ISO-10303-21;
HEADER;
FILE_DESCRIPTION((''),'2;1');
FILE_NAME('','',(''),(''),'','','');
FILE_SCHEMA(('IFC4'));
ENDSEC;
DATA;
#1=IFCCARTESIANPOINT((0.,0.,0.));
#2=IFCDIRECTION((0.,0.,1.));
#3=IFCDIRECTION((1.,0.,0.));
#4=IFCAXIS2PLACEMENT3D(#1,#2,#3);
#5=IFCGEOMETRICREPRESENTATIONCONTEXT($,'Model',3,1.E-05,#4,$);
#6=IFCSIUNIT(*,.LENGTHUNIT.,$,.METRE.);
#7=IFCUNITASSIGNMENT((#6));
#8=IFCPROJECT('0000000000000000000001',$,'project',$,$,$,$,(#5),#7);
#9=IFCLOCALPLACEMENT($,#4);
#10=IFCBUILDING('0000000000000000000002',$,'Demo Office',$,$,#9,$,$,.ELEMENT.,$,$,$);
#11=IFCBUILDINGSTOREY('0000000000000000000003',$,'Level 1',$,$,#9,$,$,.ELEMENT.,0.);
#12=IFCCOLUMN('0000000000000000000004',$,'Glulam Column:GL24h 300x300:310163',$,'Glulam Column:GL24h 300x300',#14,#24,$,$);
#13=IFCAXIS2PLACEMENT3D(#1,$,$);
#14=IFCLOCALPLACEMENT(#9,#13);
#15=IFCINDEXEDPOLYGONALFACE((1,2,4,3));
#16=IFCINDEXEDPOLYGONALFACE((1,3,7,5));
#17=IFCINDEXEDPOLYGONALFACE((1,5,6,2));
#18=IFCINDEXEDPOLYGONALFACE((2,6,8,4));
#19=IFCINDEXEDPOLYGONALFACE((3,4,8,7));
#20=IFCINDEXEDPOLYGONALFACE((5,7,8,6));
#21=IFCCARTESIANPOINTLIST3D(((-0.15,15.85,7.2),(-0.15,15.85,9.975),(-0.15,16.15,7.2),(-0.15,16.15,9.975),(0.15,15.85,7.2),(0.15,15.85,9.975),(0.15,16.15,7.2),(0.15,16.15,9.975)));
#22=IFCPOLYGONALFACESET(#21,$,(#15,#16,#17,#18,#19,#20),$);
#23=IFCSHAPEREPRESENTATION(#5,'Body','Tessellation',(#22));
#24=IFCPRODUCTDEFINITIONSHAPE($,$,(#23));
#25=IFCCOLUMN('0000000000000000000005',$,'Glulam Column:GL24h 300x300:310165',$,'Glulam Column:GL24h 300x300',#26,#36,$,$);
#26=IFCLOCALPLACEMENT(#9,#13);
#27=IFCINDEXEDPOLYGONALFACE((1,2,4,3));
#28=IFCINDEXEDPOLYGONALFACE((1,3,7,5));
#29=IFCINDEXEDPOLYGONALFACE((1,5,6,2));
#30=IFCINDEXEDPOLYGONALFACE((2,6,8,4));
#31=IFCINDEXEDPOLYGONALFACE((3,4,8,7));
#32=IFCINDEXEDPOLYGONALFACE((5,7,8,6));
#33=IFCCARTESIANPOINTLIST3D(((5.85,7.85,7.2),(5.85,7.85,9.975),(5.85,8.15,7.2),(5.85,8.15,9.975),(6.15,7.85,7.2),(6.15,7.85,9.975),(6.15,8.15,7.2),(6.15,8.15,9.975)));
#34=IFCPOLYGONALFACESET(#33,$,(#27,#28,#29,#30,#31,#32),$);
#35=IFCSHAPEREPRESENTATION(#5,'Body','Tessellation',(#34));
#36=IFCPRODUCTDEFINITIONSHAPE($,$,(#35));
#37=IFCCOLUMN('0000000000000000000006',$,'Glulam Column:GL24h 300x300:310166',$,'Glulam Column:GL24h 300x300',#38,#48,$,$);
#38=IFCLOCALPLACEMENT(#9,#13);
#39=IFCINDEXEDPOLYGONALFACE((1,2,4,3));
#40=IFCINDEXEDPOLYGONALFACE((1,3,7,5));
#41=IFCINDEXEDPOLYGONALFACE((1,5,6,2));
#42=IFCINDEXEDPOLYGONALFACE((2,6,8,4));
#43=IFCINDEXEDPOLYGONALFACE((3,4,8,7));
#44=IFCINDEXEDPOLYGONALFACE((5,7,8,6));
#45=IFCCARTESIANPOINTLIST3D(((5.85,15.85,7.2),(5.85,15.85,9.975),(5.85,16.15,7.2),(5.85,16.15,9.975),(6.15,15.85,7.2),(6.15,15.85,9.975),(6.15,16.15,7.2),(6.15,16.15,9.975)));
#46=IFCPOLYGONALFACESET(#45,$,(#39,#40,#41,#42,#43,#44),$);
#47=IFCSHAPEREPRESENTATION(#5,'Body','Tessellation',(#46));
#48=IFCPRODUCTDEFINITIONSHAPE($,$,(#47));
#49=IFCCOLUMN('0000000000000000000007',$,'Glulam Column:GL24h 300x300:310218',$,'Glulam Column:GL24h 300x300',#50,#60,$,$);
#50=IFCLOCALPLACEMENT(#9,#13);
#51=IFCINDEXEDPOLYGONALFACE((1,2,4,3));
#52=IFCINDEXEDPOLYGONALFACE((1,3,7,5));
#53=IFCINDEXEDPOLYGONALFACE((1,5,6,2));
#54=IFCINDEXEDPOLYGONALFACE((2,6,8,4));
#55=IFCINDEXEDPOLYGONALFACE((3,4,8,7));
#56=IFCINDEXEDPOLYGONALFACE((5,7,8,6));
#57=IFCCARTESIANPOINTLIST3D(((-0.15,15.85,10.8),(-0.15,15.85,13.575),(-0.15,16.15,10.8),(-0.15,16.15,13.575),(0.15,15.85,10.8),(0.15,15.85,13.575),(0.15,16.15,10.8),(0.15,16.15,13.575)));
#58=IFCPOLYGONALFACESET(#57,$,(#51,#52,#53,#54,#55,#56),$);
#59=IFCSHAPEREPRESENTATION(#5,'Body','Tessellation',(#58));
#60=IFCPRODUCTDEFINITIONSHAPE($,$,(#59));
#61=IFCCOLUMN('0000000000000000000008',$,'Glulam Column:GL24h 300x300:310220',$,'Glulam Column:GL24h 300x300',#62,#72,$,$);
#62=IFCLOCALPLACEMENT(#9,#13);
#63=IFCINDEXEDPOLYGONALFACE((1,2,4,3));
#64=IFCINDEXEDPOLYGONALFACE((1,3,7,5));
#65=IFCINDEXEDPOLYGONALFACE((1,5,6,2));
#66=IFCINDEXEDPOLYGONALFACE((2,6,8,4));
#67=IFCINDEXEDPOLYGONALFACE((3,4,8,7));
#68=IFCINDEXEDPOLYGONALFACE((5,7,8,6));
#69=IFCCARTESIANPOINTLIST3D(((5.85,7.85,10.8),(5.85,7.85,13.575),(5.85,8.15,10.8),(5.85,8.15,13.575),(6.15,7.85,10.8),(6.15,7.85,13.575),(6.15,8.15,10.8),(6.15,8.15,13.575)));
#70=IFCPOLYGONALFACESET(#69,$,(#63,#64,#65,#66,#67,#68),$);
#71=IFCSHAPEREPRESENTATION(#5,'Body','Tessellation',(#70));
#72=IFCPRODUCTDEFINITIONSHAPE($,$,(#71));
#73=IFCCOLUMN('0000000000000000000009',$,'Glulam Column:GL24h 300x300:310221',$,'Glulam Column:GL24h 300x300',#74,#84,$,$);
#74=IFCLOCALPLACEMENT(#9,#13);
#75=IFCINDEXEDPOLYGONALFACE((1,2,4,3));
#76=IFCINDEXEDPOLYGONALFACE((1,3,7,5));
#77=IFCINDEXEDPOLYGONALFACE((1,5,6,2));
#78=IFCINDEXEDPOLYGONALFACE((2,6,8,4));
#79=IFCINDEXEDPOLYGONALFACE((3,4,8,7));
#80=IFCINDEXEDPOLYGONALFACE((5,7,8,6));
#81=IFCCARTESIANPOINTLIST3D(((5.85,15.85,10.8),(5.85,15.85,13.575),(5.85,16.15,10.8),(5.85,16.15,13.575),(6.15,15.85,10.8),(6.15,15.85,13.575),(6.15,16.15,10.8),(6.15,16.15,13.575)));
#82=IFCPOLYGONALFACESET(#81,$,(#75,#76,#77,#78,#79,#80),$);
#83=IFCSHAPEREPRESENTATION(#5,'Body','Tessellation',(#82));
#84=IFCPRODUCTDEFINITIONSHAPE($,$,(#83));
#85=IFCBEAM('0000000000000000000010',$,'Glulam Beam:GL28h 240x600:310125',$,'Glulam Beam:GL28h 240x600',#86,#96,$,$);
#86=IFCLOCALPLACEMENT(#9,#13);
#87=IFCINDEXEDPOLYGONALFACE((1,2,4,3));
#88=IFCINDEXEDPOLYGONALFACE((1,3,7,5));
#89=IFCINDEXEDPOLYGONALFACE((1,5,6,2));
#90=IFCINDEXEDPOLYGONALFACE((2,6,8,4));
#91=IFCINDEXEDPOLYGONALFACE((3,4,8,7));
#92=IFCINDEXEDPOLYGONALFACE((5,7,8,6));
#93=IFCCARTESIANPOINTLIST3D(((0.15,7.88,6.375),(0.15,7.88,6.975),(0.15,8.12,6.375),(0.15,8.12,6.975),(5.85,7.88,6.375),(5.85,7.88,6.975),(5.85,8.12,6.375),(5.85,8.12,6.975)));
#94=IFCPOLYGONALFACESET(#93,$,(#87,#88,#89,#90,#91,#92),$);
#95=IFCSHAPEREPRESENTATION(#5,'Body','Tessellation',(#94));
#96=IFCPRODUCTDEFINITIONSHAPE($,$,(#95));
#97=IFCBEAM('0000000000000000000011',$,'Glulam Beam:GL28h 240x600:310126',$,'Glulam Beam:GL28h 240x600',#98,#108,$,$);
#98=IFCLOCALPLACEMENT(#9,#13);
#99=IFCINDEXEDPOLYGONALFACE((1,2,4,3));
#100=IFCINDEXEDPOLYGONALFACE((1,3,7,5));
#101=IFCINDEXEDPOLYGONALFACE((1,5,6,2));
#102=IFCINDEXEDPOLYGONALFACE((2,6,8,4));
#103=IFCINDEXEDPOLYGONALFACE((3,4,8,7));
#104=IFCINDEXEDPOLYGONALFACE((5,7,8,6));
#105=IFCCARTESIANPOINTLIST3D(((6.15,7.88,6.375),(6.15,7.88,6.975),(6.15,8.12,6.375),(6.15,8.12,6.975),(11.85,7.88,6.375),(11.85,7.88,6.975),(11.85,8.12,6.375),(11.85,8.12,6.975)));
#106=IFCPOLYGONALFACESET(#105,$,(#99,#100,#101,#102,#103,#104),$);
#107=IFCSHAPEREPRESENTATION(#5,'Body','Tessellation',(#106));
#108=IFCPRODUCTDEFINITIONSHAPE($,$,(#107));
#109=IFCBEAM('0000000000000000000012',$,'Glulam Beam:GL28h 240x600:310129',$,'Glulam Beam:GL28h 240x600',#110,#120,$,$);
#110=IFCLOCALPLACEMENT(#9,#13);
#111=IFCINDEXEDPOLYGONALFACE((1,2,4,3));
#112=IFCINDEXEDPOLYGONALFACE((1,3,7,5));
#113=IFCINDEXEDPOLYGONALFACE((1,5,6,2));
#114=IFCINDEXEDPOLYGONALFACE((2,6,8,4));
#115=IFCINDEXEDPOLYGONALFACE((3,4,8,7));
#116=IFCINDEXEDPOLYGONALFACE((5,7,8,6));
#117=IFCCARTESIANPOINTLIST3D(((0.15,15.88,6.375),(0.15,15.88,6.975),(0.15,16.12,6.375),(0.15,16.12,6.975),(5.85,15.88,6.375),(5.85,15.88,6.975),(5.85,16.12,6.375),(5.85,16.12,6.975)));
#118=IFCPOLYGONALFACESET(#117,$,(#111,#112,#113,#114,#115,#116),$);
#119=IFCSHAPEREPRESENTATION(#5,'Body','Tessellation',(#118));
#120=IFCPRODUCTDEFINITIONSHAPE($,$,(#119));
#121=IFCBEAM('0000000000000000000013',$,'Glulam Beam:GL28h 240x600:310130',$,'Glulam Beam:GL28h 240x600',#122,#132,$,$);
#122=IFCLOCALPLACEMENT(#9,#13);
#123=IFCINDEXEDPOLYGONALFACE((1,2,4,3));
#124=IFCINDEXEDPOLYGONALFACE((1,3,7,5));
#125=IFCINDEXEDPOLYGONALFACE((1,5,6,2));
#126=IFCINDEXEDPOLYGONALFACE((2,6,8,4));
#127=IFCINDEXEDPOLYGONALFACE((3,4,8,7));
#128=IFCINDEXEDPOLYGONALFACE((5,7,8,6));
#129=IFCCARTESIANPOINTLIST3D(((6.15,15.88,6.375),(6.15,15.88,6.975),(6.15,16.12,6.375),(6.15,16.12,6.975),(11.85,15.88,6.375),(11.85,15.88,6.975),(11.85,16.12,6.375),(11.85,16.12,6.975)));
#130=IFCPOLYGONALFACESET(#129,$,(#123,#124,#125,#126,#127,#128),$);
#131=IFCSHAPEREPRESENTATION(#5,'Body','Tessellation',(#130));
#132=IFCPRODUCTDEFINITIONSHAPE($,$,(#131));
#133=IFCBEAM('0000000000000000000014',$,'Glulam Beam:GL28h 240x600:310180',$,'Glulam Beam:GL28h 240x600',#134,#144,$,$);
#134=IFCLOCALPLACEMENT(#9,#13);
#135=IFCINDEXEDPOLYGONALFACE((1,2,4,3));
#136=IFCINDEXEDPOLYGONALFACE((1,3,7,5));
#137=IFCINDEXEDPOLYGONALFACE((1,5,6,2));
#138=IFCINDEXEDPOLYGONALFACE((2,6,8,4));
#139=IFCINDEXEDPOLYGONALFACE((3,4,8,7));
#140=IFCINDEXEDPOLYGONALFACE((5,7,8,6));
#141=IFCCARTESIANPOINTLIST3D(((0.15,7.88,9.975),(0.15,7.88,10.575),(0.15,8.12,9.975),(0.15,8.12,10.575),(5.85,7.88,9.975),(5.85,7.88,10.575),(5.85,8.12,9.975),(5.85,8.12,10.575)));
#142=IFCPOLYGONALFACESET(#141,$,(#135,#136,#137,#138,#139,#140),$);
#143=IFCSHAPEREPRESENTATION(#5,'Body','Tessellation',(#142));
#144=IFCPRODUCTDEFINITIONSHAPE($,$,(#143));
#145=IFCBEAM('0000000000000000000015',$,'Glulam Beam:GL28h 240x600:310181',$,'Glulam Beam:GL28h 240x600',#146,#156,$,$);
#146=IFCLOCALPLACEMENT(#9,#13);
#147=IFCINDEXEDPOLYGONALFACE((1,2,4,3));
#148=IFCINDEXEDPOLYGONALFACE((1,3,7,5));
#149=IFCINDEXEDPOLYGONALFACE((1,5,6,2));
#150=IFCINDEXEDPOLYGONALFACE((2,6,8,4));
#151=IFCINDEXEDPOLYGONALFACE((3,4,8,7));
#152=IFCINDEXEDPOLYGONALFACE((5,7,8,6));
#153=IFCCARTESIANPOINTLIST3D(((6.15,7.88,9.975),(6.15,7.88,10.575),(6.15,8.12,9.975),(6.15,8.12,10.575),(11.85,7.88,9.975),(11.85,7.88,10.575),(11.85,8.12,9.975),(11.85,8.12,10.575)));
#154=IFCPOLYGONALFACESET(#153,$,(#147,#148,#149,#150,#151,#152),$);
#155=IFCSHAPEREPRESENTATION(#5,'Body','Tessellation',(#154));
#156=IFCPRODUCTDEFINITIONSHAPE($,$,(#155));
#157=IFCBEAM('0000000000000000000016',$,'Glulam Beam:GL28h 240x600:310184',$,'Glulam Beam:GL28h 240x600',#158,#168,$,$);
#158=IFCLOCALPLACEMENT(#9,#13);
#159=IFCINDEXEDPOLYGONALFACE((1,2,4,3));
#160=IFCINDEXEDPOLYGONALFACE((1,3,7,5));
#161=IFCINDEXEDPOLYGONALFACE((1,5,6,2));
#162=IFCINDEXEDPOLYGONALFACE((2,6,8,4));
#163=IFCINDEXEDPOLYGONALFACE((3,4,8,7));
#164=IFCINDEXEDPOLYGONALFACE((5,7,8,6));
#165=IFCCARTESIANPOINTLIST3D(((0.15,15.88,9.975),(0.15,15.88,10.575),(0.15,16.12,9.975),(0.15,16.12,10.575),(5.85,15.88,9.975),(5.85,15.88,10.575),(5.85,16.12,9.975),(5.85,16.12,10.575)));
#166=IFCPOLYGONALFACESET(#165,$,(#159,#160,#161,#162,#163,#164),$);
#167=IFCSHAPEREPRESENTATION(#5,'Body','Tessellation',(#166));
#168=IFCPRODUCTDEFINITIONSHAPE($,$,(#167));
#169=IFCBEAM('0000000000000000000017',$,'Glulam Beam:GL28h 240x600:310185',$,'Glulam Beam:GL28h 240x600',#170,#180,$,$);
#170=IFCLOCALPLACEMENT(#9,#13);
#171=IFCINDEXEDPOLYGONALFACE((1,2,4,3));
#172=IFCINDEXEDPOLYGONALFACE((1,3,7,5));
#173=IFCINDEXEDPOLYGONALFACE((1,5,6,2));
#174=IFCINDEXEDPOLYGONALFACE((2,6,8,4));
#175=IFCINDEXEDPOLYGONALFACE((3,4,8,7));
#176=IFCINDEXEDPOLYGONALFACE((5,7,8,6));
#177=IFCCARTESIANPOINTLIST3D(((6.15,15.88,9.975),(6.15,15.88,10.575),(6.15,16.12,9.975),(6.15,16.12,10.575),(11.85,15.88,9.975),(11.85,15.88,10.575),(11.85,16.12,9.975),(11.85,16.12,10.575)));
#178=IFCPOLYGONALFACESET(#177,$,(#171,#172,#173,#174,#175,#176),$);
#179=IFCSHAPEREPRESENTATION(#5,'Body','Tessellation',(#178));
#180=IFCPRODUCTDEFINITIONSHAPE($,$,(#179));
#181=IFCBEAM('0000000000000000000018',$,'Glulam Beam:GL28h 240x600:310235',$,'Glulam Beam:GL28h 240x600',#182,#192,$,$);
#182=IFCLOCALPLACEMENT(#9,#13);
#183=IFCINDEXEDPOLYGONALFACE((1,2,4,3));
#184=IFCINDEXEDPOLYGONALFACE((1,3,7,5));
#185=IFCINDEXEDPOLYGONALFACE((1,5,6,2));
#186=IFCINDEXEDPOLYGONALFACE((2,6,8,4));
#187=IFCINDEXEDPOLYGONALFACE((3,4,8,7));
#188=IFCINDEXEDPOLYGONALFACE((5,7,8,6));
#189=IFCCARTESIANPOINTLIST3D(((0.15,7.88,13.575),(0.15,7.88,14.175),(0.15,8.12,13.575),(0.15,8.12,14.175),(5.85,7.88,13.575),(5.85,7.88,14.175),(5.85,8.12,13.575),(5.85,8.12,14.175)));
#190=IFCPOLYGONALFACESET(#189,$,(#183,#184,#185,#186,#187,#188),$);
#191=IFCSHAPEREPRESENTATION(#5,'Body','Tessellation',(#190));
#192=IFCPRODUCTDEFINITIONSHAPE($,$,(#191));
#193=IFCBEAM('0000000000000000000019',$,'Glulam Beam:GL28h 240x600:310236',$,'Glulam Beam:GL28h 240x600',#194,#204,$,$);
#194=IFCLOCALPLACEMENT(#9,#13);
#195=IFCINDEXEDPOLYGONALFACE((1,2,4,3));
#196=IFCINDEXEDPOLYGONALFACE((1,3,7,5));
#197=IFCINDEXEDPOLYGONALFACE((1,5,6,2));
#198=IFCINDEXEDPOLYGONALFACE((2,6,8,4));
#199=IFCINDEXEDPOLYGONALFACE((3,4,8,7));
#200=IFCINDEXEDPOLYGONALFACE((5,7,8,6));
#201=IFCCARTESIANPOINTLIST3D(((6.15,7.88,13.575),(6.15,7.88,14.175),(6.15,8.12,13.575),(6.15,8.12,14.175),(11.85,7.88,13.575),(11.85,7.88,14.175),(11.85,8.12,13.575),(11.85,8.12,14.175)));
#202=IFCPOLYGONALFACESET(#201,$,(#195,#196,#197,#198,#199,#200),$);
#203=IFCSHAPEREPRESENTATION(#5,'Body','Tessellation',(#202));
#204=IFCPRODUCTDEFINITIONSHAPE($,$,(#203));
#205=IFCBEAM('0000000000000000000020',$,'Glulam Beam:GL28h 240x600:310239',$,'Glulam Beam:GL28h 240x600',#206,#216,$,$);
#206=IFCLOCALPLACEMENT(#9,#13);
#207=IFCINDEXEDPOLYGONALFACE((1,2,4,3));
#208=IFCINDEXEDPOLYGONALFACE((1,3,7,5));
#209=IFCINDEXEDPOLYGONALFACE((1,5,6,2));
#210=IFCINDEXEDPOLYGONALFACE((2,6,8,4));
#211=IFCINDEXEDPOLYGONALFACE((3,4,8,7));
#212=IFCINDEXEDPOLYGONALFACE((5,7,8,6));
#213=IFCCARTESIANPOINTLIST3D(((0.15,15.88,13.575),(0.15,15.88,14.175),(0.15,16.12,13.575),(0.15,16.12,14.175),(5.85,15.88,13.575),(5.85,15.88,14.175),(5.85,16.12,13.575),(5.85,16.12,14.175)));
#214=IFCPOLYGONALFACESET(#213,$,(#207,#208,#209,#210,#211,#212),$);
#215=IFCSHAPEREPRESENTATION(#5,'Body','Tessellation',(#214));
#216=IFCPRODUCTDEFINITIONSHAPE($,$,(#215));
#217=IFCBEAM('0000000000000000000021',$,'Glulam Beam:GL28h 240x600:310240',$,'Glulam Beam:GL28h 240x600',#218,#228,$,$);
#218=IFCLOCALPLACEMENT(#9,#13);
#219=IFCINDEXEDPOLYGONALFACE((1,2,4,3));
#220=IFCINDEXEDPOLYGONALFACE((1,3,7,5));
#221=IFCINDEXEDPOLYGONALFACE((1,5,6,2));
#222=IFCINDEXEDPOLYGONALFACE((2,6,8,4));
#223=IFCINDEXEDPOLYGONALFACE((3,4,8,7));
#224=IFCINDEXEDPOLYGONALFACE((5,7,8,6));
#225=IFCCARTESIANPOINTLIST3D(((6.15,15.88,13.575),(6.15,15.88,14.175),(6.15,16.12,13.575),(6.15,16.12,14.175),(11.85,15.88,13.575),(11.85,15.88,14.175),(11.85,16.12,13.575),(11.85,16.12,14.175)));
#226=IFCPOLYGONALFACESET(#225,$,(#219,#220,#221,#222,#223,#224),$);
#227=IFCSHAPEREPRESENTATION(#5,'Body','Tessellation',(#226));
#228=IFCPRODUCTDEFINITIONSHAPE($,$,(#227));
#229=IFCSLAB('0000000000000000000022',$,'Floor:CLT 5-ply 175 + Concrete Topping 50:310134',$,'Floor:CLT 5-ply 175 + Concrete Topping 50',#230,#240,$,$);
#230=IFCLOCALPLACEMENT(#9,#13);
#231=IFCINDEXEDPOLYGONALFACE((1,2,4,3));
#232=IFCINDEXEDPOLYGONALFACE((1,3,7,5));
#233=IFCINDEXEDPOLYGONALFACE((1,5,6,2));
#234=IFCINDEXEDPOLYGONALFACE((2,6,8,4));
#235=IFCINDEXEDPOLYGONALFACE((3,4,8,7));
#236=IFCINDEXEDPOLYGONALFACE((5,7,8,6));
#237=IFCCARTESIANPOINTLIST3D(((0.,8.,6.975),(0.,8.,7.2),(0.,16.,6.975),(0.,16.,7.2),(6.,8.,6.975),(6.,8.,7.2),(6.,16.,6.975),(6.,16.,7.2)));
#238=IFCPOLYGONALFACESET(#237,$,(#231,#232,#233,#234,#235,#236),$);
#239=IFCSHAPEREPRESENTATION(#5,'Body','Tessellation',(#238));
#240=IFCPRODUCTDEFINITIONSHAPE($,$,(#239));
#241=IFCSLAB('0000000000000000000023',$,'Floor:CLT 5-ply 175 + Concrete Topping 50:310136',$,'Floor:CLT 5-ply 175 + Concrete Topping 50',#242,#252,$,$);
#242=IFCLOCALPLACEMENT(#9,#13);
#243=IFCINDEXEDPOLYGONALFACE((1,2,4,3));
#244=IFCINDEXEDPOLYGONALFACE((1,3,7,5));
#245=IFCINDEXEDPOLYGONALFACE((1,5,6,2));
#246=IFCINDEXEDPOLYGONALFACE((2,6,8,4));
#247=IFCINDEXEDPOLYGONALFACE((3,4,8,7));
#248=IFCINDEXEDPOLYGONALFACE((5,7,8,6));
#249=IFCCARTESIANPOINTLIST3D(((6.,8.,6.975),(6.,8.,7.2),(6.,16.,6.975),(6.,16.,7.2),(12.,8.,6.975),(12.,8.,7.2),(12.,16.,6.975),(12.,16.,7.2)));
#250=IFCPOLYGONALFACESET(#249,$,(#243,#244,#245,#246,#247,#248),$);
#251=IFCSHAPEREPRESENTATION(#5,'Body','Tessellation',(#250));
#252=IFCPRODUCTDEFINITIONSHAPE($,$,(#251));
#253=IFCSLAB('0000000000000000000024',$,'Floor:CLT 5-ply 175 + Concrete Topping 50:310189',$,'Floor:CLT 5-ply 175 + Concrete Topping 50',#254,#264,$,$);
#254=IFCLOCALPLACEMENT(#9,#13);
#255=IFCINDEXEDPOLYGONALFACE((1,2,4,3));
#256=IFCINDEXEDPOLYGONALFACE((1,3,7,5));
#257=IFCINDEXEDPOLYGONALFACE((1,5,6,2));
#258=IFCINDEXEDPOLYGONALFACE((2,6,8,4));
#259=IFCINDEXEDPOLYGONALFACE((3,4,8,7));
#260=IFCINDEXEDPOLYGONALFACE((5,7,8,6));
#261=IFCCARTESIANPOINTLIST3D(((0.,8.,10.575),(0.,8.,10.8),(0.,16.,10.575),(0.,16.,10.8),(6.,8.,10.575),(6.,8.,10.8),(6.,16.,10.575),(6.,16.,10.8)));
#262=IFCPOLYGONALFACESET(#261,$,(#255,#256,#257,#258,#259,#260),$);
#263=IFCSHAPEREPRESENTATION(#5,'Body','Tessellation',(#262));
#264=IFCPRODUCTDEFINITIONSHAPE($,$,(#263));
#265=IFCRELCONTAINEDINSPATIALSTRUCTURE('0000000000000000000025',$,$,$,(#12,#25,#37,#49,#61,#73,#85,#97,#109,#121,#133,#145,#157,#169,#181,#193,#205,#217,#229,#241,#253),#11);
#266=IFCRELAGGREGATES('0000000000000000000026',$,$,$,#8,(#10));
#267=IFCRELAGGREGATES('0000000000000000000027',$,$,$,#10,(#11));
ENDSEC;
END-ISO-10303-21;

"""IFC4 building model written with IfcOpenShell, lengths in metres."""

from ifc_helpers import new_model, si_unit, frame, origin_with_axes, origin_2d, place, context, project, spatial, rectangle, extrude, element, save


model = new_model("IFC4")

# Units and contexts
model_context = context("Model", 3, precision=1e-05, world=origin_with_axes())
ifc_project = project(units=[si_unit("LENGTHUNIT", "METRE")], contexts=[model_context])

# Building, storey
placement = place(None, origin_with_axes())
building = spatial("IfcBuilding", under=ifc_project, at=placement, Name="Demo Office", CompositionType="ELEMENT")
storey = spatial("IfcBuildingStorey", under=building, at=placement, Name="Level 1", CompositionType="ELEMENT", Elevation=0.0)

# Columns
for number, where, name in (
    (1, (0.0, 16.0, 7.2), "Glulam Column:GL24h 300x300:310163"),
    (2, (6.0, 8.0, 7.2), "Glulam Column:GL24h 300x300:310165"),
    (3, (6.0, 16.0, 7.2), "Glulam Column:GL24h 300x300:310166"),
    (4, (0.0, 16.0, 10.8), "Glulam Column:GL24h 300x300:310218"),
    (5, (6.0, 8.0, 10.8), "Glulam Column:GL24h 300x300:310220"),
    (6, (6.0, 16.0, 10.8), "Glulam Column:GL24h 300x300:310221"),
):
    element("IfcColumn", number, at=place(placement, frame(where)), inside=storey, Name=name, ObjectType="Glulam Column:GL24h 300x300", context=model_context, shape_type="SweptSolid", body=[
        extrude(rectangle(XDim=0.3, YDim=0.3, at=origin_2d()), origin_with_axes(), (0.0, 0.0, 1.0), 2.775),
    ])

# Beams
for number, where, name in (
    (7, (3.0, 8.0, 6.375), "Glulam Beam:GL28h 240x600:310125"),
    (8, (9.0, 8.0, 6.375), "Glulam Beam:GL28h 240x600:310126"),
    (9, (3.0, 16.0, 6.375), "Glulam Beam:GL28h 240x600:310129"),
    (10, (9.0, 16.0, 6.375), "Glulam Beam:GL28h 240x600:310130"),
    (11, (3.0, 8.0, 9.975), "Glulam Beam:GL28h 240x600:310180"),
    (12, (9.0, 8.0, 9.975), "Glulam Beam:GL28h 240x600:310181"),
    (13, (3.0, 16.0, 9.975), "Glulam Beam:GL28h 240x600:310184"),
    (14, (9.0, 16.0, 9.975), "Glulam Beam:GL28h 240x600:310185"),
    (15, (3.0, 8.0, 13.575), "Glulam Beam:GL28h 240x600:310235"),
    (16, (9.0, 8.0, 13.575), "Glulam Beam:GL28h 240x600:310236"),
    (17, (3.0, 16.0, 13.575), "Glulam Beam:GL28h 240x600:310239"),
    (18, (9.0, 16.0, 13.575), "Glulam Beam:GL28h 240x600:310240"),
):
    element("IfcBeam", number, at=place(placement, frame(where)), inside=storey, Name=name, ObjectType="Glulam Beam:GL28h 240x600", context=model_context, shape_type="SweptSolid", body=[
        extrude(rectangle(XDim=5.7, YDim=0.24, at=origin_2d()), origin_with_axes(), (0.0, 0.0, 1.0), 0.6),
    ])

# Slabs
for number, where, name in (
    (19, (3.0, 12.0, 6.975), "Floor:CLT 5-ply 175 + Concrete Topping 50:310134"),
    (20, (9.0, 12.0, 6.975), "Floor:CLT 5-ply 175 + Concrete Topping 50:310136"),
    (21, (3.0, 12.0, 10.575), "Floor:CLT 5-ply 175 + Concrete Topping 50:310189"),
):
    element("IfcSlab", number, at=place(placement, frame(where)), inside=storey, Name=name, ObjectType="Floor:CLT 5-ply 175 + Concrete Topping 50", context=model_context, shape_type="SweptSolid", body=[
        extrude(rectangle(XDim=6.0, YDim=8.0, at=origin_2d()), origin_with_axes(), (0.0, 0.0, 1.0), 0.225),
    ])

save(model, "model.ifc")
